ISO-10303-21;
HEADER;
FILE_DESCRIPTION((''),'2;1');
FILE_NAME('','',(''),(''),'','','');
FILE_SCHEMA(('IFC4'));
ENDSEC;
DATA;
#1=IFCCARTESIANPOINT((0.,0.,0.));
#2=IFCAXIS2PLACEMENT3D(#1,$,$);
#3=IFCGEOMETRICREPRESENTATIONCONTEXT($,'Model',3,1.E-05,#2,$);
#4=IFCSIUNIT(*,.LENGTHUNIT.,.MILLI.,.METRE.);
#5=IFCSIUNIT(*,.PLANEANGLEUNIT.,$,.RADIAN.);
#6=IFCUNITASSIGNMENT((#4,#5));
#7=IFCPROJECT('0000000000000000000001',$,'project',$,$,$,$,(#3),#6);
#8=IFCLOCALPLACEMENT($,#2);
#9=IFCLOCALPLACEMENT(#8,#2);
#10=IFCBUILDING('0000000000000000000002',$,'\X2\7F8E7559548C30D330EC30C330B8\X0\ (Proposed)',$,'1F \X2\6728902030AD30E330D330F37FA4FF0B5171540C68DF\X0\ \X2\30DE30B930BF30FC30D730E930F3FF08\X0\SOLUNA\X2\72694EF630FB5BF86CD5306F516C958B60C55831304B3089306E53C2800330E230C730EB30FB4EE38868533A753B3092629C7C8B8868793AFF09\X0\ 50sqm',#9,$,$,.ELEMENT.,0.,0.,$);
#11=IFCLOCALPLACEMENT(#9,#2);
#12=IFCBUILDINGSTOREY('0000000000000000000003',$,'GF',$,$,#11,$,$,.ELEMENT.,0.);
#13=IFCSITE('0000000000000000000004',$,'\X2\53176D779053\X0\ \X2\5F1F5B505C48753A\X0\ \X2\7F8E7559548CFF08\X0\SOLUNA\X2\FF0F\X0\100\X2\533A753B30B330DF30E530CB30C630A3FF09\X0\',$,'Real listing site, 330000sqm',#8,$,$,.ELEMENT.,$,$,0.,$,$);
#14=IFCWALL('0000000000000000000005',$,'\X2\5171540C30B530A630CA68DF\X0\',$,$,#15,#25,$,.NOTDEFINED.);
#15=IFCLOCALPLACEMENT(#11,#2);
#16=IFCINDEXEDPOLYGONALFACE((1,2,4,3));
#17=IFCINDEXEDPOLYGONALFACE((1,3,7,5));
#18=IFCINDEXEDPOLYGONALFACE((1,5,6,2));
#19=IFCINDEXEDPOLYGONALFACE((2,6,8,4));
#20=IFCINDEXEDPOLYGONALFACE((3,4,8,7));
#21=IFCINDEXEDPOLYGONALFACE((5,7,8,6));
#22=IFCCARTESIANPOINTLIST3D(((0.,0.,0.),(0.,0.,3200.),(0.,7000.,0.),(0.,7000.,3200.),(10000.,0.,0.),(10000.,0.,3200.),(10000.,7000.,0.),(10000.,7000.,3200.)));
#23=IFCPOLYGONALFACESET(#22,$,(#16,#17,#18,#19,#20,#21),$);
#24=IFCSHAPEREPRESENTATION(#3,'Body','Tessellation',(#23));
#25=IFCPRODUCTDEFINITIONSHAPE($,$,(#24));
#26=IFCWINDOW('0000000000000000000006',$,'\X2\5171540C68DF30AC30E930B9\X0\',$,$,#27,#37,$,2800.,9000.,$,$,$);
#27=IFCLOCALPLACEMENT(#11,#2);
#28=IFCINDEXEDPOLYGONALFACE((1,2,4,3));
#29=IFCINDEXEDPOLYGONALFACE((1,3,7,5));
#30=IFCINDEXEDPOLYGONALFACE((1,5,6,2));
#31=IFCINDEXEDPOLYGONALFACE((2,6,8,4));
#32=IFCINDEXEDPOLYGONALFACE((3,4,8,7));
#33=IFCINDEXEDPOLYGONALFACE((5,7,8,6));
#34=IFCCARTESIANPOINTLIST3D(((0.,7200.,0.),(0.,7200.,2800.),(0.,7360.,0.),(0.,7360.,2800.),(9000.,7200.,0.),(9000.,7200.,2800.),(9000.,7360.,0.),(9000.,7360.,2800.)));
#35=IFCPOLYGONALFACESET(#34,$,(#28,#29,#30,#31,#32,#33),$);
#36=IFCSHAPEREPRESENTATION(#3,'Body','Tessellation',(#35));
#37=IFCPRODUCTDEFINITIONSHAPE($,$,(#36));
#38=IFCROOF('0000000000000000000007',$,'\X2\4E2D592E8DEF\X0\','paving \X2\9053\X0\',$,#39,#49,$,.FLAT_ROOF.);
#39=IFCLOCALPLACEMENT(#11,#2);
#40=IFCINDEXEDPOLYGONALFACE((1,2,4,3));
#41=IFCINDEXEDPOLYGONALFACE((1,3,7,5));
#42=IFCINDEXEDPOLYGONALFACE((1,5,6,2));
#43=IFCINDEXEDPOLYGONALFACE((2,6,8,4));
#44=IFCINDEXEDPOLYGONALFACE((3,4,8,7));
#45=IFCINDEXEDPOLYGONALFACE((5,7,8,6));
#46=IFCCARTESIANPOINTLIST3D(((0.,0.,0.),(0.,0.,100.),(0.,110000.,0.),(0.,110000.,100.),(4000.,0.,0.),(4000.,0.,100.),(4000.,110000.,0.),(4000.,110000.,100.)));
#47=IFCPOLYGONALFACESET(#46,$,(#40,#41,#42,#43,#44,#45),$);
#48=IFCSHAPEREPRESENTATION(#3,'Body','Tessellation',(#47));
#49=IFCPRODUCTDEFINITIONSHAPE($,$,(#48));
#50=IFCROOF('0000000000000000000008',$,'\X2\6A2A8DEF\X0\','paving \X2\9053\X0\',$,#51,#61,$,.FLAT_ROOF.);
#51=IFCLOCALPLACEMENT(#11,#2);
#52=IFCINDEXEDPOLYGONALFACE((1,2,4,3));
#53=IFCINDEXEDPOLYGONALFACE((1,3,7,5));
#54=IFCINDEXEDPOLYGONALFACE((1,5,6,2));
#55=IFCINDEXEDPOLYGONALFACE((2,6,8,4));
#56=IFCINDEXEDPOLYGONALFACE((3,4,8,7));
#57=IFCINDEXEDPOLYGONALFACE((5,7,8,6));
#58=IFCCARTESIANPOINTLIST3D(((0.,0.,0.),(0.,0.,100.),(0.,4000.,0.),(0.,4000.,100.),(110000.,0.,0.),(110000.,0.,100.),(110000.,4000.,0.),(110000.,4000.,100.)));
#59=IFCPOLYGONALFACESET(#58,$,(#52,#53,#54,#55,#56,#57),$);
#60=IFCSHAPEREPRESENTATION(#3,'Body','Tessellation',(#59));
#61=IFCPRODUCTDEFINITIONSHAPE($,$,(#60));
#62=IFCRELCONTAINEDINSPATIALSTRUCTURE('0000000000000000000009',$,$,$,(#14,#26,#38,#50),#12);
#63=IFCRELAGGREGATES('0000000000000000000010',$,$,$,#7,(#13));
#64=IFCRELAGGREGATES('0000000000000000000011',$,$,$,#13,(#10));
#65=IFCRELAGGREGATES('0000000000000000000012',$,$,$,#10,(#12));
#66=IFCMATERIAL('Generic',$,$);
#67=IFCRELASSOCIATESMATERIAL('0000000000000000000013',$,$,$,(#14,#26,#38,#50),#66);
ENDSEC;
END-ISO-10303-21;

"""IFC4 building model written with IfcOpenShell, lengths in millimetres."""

from ifc_helpers import new_model, si_unit, frame, frame_2d, origin, place, context, project, spatial, rectangle, extrude, material, element, fill, save


model = new_model("IFC4")

# Units and contexts
model_context = context("Model", 3, precision=1e-05, world=origin())
ifc_project = project(units=[si_unit("LENGTHUNIT", "METRE", prefix="MILLI"), si_unit("PLANEANGLEUNIT", "RADIAN")], contexts=[model_context])

# Site, building, storey
site_placement = place(None, origin())
site = spatial("IfcSite", under=ifc_project, at=site_placement, Name="北海道 弟子屈町 美留和（SOLUNA／100区画コミュニティ）", ObjectType="Real listing site, 330000sqm", CompositionType="ELEMENT", RefElevation=0.0)
building_placement = place(site_placement, origin())
building = spatial("IfcBuilding", under=site, at=building_placement, Name="美留和ビレッジ (Proposed)", ObjectType="1F 木造キャビン群＋共同棟 マスタープラン（SOLUNA物件・寸法は公開情報からの参考モデル・代表区画を抜粋表示） 50sqm", CompositionType="ELEMENT", ElevationOfRefHeight=0.0, ElevationOfTerrain=0.0)
storey_placement = place(building_placement, origin())
storey = spatial("IfcBuildingStorey", under=building, at=storey_placement, Name="GF", CompositionType="ELEMENT", Elevation=0.0)

# Wall, opening, window
ifc_material_1 = material(Name="Generic")
wall_1_placement = place(storey_placement, origin())
wall_1 = element("IfcWall", 1, at=wall_1_placement, inside=storey, material=ifc_material_1, Name="共同サウナ棟", PredefinedType="NOTDEFINED", context=model_context, shape_type="SweptSolid", body=[
    extrude(rectangle(XDim=10000.0, YDim=7000.0, at=frame_2d((5000.0, 3500.0))), origin(), (0.0, 0.0, 1.0), 3200.0),
])
opening_1_placement = place(storey_placement, frame((0.0, 3600.0, 0.0)))
opening_1 = element("IfcOpeningElement", 2, at=opening_1_placement, cuts=wall_1, PredefinedType="NOTDEFINED", context=model_context, shape_type="SweptSolid", body=[
    extrude(rectangle(XDim=9000.0, YDim=160.0, at=frame_2d((4500.0, 80.0))), frame((0.0, 3600.0, 0.0)), (0.0, 0.0, 1.0), 2800.0),
])
window_1_placement = place(storey_placement, frame((0.0, 3600.0, 0.0)))
window_1 = element("IfcWindow", 3, at=window_1_placement, inside=storey, material=ifc_material_1, Name="共同棟ガラス", OverallHeight=2800.0, OverallWidth=9000.0, context=model_context, shape_type="SweptSolid", body=[
    extrude(rectangle(XDim=9000.0, YDim=160.0, at=frame_2d((4500.0, 80.0))), frame((0.0, 3600.0, 0.0)), (0.0, 0.0, 1.0), 2800.0),
])
fill(opening_1, window_1)

# Roofs
roof_1_placement = place(storey_placement, origin())
element("IfcRoof", 4, at=roof_1_placement, inside=storey, material=ifc_material_1, Name="中央路", Description="paving 道", PredefinedType="FLAT_ROOF", context=model_context, shape_type="SweptSolid", body=[
    extrude(rectangle(XDim=4000.0, YDim=110000.0, at=frame_2d((2000.0, 55000.0))), origin(), (0.0, 0.0, 1.0), 100.0),
])
roof_2_placement = place(storey_placement, origin())
element("IfcRoof", 5, at=roof_2_placement, inside=storey, material=ifc_material_1, Name="横路", Description="paving 道", PredefinedType="FLAT_ROOF", context=model_context, shape_type="SweptSolid", body=[
    extrude(rectangle(XDim=110000.0, YDim=4000.0, at=frame_2d((55000.0, 2000.0))), origin(), (0.0, 0.0, 1.0), 100.0),
])

save(model, "model.ifc")
